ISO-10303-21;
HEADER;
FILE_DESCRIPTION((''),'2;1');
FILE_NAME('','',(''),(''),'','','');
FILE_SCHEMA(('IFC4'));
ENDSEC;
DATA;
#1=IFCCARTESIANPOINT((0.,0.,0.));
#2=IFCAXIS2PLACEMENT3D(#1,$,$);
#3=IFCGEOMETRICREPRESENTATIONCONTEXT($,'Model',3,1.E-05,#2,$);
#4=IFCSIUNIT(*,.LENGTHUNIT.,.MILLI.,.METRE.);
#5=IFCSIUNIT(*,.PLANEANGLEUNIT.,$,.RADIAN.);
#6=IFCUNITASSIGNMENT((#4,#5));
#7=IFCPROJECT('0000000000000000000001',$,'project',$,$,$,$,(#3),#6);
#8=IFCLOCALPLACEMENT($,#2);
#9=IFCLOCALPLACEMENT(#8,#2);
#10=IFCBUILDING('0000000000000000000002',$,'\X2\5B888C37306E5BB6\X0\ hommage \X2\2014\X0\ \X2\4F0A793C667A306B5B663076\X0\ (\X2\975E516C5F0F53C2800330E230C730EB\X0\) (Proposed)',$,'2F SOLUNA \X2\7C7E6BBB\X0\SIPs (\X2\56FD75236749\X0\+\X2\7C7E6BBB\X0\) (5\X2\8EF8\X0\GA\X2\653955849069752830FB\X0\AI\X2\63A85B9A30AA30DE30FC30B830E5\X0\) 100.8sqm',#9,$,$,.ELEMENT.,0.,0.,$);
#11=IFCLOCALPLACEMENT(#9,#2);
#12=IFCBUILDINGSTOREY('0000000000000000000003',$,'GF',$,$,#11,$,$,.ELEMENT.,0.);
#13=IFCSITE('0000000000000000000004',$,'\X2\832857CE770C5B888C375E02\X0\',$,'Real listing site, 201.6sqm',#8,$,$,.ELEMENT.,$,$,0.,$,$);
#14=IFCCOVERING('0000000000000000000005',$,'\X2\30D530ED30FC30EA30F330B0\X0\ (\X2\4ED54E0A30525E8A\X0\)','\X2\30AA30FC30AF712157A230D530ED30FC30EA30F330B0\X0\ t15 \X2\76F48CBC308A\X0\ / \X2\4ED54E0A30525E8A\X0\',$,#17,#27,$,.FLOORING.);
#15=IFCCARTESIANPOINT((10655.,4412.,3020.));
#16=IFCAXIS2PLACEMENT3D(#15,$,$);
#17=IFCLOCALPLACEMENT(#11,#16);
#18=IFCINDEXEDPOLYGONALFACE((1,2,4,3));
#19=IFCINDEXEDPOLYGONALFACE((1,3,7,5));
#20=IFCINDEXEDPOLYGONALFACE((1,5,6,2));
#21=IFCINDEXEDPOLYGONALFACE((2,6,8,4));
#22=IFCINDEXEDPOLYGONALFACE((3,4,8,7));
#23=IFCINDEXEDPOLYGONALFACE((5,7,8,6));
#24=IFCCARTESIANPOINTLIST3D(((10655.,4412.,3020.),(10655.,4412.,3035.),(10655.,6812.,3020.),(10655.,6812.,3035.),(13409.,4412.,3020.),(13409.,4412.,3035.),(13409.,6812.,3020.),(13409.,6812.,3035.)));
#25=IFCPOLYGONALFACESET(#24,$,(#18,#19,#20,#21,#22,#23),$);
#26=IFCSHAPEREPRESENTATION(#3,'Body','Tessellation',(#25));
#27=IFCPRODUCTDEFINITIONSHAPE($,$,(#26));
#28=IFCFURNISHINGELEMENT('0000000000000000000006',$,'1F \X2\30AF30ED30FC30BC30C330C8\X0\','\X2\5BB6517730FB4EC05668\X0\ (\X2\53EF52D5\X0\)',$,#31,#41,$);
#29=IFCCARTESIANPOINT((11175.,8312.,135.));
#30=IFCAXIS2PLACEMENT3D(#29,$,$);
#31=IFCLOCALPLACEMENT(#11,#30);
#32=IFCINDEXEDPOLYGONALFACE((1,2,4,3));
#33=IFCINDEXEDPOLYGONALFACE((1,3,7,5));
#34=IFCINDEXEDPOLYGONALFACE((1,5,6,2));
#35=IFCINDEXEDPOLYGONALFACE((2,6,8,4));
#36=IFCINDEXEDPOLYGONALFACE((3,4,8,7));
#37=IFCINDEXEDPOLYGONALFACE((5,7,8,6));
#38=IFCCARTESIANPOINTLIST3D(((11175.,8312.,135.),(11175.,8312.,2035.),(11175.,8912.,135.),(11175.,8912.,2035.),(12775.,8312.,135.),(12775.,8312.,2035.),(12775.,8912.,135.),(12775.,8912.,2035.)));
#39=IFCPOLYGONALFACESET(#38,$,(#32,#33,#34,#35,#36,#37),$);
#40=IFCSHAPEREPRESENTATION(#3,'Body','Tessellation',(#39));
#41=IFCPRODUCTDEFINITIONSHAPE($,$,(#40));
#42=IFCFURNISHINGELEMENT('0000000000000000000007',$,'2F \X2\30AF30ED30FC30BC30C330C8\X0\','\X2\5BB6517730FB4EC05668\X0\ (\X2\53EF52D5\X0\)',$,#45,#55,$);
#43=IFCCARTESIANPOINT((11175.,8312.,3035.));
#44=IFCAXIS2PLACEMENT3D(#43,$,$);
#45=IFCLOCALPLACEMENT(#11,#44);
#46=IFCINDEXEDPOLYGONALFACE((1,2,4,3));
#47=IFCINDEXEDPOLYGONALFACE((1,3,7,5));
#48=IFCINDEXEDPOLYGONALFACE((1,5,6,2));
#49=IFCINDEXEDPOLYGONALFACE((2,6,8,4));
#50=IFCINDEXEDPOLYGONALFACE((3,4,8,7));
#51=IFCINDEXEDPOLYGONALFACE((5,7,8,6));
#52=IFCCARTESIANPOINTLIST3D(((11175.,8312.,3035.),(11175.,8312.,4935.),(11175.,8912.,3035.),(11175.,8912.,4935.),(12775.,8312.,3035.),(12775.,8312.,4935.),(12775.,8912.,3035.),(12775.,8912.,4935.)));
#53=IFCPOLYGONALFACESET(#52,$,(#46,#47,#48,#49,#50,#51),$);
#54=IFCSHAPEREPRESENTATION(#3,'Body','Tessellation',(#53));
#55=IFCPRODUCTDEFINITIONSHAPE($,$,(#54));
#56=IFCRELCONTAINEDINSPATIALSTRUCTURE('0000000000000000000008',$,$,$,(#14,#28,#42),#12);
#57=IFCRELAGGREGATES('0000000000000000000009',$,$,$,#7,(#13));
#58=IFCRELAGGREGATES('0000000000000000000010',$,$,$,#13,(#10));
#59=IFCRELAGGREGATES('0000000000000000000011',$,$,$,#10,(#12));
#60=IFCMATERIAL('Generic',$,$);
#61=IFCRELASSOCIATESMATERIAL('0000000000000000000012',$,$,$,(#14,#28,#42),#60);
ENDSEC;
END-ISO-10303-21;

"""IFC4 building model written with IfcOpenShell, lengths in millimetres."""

from ifc_helpers import new_model, si_unit, frame, frame_2d, origin, place, context, project, spatial, rectangle, extrude, material, element, save


model = new_model("IFC4")

# Units and contexts
model_context = context("Model", 3, precision=1e-05, world=origin())
ifc_project = project(units=[si_unit("LENGTHUNIT", "METRE", prefix="MILLI"), si_unit("PLANEANGLEUNIT", "RADIAN")], contexts=[model_context])

# Site, building, storey
site_placement = place(None, origin())
site = spatial("IfcSite", under=ifc_project, at=site_placement, Name="茨城県守谷市", ObjectType="Real listing site, 201.6sqm", CompositionType="ELEMENT", RefElevation=0.0)
building_placement = place(site_placement, origin())
building = spatial("IfcBuilding", under=site, at=building_placement, Name="守谷の家 hommage — 伊礼智に学ぶ (非公式参考モデル) (Proposed)", ObjectType="2F SOLUNA 籾殻SIPs (国産杉+籾殻) (5軸GA改善適用・AI推定オマージュ) 100.8sqm", CompositionType="ELEMENT", ElevationOfRefHeight=0.0, ElevationOfTerrain=0.0)
storey_placement = place(building_placement, origin())
storey = spatial("IfcBuildingStorey", under=building, at=storey_placement, Name="GF", CompositionType="ELEMENT", Elevation=0.0)

# Covering
ifc_material_1 = material(Name="Generic")
covering_1_placement = place(storey_placement, frame((10655.0, 4412.0, 3020.0)))
element("IfcCovering", 1, at=covering_1_placement, inside=storey, material=ifc_material_1, Name="フローリング (仕上げ床)", Description="オーク無垢フローリング t15 直貼り / 仕上げ床", PredefinedType="FLOORING", context=model_context, shape_type="SweptSolid", body=[
    extrude(rectangle(XDim=2754.0, YDim=2400.0, at=frame_2d((1377.0, 1200.0))), frame((10655.0, 4412.0, 3020.0)), (0.0, 0.0, 1.0), 15.0),
])

# Furnishing elements
furnishing_1_placement = place(storey_placement, frame((11175.0, 8312.0, 135.0)))
element("IfcFurnishingElement", 2, at=furnishing_1_placement, inside=storey, material=ifc_material_1, Name="1F クローゼット", Description="家具・什器 (可動)", context=model_context, shape_type="SweptSolid", body=[
    extrude(rectangle(XDim=1600.0, YDim=600.0, at=frame_2d((800.0, 300.0))), frame((11175.0, 8312.0, 135.0)), (0.0, 0.0, 1.0), 1900.0),
])
furnishing_2_placement = place(storey_placement, frame((11175.0, 8312.0, 3035.0)))
element("IfcFurnishingElement", 3, at=furnishing_2_placement, inside=storey, material=ifc_material_1, Name="2F クローゼット", Description="家具・什器 (可動)", context=model_context, shape_type="SweptSolid", body=[
    extrude(rectangle(XDim=1600.0, YDim=600.0, at=frame_2d((800.0, 300.0))), frame((11175.0, 8312.0, 3035.0)), (0.0, 0.0, 1.0), 1900.0),
])

save(model, "model.ifc")
